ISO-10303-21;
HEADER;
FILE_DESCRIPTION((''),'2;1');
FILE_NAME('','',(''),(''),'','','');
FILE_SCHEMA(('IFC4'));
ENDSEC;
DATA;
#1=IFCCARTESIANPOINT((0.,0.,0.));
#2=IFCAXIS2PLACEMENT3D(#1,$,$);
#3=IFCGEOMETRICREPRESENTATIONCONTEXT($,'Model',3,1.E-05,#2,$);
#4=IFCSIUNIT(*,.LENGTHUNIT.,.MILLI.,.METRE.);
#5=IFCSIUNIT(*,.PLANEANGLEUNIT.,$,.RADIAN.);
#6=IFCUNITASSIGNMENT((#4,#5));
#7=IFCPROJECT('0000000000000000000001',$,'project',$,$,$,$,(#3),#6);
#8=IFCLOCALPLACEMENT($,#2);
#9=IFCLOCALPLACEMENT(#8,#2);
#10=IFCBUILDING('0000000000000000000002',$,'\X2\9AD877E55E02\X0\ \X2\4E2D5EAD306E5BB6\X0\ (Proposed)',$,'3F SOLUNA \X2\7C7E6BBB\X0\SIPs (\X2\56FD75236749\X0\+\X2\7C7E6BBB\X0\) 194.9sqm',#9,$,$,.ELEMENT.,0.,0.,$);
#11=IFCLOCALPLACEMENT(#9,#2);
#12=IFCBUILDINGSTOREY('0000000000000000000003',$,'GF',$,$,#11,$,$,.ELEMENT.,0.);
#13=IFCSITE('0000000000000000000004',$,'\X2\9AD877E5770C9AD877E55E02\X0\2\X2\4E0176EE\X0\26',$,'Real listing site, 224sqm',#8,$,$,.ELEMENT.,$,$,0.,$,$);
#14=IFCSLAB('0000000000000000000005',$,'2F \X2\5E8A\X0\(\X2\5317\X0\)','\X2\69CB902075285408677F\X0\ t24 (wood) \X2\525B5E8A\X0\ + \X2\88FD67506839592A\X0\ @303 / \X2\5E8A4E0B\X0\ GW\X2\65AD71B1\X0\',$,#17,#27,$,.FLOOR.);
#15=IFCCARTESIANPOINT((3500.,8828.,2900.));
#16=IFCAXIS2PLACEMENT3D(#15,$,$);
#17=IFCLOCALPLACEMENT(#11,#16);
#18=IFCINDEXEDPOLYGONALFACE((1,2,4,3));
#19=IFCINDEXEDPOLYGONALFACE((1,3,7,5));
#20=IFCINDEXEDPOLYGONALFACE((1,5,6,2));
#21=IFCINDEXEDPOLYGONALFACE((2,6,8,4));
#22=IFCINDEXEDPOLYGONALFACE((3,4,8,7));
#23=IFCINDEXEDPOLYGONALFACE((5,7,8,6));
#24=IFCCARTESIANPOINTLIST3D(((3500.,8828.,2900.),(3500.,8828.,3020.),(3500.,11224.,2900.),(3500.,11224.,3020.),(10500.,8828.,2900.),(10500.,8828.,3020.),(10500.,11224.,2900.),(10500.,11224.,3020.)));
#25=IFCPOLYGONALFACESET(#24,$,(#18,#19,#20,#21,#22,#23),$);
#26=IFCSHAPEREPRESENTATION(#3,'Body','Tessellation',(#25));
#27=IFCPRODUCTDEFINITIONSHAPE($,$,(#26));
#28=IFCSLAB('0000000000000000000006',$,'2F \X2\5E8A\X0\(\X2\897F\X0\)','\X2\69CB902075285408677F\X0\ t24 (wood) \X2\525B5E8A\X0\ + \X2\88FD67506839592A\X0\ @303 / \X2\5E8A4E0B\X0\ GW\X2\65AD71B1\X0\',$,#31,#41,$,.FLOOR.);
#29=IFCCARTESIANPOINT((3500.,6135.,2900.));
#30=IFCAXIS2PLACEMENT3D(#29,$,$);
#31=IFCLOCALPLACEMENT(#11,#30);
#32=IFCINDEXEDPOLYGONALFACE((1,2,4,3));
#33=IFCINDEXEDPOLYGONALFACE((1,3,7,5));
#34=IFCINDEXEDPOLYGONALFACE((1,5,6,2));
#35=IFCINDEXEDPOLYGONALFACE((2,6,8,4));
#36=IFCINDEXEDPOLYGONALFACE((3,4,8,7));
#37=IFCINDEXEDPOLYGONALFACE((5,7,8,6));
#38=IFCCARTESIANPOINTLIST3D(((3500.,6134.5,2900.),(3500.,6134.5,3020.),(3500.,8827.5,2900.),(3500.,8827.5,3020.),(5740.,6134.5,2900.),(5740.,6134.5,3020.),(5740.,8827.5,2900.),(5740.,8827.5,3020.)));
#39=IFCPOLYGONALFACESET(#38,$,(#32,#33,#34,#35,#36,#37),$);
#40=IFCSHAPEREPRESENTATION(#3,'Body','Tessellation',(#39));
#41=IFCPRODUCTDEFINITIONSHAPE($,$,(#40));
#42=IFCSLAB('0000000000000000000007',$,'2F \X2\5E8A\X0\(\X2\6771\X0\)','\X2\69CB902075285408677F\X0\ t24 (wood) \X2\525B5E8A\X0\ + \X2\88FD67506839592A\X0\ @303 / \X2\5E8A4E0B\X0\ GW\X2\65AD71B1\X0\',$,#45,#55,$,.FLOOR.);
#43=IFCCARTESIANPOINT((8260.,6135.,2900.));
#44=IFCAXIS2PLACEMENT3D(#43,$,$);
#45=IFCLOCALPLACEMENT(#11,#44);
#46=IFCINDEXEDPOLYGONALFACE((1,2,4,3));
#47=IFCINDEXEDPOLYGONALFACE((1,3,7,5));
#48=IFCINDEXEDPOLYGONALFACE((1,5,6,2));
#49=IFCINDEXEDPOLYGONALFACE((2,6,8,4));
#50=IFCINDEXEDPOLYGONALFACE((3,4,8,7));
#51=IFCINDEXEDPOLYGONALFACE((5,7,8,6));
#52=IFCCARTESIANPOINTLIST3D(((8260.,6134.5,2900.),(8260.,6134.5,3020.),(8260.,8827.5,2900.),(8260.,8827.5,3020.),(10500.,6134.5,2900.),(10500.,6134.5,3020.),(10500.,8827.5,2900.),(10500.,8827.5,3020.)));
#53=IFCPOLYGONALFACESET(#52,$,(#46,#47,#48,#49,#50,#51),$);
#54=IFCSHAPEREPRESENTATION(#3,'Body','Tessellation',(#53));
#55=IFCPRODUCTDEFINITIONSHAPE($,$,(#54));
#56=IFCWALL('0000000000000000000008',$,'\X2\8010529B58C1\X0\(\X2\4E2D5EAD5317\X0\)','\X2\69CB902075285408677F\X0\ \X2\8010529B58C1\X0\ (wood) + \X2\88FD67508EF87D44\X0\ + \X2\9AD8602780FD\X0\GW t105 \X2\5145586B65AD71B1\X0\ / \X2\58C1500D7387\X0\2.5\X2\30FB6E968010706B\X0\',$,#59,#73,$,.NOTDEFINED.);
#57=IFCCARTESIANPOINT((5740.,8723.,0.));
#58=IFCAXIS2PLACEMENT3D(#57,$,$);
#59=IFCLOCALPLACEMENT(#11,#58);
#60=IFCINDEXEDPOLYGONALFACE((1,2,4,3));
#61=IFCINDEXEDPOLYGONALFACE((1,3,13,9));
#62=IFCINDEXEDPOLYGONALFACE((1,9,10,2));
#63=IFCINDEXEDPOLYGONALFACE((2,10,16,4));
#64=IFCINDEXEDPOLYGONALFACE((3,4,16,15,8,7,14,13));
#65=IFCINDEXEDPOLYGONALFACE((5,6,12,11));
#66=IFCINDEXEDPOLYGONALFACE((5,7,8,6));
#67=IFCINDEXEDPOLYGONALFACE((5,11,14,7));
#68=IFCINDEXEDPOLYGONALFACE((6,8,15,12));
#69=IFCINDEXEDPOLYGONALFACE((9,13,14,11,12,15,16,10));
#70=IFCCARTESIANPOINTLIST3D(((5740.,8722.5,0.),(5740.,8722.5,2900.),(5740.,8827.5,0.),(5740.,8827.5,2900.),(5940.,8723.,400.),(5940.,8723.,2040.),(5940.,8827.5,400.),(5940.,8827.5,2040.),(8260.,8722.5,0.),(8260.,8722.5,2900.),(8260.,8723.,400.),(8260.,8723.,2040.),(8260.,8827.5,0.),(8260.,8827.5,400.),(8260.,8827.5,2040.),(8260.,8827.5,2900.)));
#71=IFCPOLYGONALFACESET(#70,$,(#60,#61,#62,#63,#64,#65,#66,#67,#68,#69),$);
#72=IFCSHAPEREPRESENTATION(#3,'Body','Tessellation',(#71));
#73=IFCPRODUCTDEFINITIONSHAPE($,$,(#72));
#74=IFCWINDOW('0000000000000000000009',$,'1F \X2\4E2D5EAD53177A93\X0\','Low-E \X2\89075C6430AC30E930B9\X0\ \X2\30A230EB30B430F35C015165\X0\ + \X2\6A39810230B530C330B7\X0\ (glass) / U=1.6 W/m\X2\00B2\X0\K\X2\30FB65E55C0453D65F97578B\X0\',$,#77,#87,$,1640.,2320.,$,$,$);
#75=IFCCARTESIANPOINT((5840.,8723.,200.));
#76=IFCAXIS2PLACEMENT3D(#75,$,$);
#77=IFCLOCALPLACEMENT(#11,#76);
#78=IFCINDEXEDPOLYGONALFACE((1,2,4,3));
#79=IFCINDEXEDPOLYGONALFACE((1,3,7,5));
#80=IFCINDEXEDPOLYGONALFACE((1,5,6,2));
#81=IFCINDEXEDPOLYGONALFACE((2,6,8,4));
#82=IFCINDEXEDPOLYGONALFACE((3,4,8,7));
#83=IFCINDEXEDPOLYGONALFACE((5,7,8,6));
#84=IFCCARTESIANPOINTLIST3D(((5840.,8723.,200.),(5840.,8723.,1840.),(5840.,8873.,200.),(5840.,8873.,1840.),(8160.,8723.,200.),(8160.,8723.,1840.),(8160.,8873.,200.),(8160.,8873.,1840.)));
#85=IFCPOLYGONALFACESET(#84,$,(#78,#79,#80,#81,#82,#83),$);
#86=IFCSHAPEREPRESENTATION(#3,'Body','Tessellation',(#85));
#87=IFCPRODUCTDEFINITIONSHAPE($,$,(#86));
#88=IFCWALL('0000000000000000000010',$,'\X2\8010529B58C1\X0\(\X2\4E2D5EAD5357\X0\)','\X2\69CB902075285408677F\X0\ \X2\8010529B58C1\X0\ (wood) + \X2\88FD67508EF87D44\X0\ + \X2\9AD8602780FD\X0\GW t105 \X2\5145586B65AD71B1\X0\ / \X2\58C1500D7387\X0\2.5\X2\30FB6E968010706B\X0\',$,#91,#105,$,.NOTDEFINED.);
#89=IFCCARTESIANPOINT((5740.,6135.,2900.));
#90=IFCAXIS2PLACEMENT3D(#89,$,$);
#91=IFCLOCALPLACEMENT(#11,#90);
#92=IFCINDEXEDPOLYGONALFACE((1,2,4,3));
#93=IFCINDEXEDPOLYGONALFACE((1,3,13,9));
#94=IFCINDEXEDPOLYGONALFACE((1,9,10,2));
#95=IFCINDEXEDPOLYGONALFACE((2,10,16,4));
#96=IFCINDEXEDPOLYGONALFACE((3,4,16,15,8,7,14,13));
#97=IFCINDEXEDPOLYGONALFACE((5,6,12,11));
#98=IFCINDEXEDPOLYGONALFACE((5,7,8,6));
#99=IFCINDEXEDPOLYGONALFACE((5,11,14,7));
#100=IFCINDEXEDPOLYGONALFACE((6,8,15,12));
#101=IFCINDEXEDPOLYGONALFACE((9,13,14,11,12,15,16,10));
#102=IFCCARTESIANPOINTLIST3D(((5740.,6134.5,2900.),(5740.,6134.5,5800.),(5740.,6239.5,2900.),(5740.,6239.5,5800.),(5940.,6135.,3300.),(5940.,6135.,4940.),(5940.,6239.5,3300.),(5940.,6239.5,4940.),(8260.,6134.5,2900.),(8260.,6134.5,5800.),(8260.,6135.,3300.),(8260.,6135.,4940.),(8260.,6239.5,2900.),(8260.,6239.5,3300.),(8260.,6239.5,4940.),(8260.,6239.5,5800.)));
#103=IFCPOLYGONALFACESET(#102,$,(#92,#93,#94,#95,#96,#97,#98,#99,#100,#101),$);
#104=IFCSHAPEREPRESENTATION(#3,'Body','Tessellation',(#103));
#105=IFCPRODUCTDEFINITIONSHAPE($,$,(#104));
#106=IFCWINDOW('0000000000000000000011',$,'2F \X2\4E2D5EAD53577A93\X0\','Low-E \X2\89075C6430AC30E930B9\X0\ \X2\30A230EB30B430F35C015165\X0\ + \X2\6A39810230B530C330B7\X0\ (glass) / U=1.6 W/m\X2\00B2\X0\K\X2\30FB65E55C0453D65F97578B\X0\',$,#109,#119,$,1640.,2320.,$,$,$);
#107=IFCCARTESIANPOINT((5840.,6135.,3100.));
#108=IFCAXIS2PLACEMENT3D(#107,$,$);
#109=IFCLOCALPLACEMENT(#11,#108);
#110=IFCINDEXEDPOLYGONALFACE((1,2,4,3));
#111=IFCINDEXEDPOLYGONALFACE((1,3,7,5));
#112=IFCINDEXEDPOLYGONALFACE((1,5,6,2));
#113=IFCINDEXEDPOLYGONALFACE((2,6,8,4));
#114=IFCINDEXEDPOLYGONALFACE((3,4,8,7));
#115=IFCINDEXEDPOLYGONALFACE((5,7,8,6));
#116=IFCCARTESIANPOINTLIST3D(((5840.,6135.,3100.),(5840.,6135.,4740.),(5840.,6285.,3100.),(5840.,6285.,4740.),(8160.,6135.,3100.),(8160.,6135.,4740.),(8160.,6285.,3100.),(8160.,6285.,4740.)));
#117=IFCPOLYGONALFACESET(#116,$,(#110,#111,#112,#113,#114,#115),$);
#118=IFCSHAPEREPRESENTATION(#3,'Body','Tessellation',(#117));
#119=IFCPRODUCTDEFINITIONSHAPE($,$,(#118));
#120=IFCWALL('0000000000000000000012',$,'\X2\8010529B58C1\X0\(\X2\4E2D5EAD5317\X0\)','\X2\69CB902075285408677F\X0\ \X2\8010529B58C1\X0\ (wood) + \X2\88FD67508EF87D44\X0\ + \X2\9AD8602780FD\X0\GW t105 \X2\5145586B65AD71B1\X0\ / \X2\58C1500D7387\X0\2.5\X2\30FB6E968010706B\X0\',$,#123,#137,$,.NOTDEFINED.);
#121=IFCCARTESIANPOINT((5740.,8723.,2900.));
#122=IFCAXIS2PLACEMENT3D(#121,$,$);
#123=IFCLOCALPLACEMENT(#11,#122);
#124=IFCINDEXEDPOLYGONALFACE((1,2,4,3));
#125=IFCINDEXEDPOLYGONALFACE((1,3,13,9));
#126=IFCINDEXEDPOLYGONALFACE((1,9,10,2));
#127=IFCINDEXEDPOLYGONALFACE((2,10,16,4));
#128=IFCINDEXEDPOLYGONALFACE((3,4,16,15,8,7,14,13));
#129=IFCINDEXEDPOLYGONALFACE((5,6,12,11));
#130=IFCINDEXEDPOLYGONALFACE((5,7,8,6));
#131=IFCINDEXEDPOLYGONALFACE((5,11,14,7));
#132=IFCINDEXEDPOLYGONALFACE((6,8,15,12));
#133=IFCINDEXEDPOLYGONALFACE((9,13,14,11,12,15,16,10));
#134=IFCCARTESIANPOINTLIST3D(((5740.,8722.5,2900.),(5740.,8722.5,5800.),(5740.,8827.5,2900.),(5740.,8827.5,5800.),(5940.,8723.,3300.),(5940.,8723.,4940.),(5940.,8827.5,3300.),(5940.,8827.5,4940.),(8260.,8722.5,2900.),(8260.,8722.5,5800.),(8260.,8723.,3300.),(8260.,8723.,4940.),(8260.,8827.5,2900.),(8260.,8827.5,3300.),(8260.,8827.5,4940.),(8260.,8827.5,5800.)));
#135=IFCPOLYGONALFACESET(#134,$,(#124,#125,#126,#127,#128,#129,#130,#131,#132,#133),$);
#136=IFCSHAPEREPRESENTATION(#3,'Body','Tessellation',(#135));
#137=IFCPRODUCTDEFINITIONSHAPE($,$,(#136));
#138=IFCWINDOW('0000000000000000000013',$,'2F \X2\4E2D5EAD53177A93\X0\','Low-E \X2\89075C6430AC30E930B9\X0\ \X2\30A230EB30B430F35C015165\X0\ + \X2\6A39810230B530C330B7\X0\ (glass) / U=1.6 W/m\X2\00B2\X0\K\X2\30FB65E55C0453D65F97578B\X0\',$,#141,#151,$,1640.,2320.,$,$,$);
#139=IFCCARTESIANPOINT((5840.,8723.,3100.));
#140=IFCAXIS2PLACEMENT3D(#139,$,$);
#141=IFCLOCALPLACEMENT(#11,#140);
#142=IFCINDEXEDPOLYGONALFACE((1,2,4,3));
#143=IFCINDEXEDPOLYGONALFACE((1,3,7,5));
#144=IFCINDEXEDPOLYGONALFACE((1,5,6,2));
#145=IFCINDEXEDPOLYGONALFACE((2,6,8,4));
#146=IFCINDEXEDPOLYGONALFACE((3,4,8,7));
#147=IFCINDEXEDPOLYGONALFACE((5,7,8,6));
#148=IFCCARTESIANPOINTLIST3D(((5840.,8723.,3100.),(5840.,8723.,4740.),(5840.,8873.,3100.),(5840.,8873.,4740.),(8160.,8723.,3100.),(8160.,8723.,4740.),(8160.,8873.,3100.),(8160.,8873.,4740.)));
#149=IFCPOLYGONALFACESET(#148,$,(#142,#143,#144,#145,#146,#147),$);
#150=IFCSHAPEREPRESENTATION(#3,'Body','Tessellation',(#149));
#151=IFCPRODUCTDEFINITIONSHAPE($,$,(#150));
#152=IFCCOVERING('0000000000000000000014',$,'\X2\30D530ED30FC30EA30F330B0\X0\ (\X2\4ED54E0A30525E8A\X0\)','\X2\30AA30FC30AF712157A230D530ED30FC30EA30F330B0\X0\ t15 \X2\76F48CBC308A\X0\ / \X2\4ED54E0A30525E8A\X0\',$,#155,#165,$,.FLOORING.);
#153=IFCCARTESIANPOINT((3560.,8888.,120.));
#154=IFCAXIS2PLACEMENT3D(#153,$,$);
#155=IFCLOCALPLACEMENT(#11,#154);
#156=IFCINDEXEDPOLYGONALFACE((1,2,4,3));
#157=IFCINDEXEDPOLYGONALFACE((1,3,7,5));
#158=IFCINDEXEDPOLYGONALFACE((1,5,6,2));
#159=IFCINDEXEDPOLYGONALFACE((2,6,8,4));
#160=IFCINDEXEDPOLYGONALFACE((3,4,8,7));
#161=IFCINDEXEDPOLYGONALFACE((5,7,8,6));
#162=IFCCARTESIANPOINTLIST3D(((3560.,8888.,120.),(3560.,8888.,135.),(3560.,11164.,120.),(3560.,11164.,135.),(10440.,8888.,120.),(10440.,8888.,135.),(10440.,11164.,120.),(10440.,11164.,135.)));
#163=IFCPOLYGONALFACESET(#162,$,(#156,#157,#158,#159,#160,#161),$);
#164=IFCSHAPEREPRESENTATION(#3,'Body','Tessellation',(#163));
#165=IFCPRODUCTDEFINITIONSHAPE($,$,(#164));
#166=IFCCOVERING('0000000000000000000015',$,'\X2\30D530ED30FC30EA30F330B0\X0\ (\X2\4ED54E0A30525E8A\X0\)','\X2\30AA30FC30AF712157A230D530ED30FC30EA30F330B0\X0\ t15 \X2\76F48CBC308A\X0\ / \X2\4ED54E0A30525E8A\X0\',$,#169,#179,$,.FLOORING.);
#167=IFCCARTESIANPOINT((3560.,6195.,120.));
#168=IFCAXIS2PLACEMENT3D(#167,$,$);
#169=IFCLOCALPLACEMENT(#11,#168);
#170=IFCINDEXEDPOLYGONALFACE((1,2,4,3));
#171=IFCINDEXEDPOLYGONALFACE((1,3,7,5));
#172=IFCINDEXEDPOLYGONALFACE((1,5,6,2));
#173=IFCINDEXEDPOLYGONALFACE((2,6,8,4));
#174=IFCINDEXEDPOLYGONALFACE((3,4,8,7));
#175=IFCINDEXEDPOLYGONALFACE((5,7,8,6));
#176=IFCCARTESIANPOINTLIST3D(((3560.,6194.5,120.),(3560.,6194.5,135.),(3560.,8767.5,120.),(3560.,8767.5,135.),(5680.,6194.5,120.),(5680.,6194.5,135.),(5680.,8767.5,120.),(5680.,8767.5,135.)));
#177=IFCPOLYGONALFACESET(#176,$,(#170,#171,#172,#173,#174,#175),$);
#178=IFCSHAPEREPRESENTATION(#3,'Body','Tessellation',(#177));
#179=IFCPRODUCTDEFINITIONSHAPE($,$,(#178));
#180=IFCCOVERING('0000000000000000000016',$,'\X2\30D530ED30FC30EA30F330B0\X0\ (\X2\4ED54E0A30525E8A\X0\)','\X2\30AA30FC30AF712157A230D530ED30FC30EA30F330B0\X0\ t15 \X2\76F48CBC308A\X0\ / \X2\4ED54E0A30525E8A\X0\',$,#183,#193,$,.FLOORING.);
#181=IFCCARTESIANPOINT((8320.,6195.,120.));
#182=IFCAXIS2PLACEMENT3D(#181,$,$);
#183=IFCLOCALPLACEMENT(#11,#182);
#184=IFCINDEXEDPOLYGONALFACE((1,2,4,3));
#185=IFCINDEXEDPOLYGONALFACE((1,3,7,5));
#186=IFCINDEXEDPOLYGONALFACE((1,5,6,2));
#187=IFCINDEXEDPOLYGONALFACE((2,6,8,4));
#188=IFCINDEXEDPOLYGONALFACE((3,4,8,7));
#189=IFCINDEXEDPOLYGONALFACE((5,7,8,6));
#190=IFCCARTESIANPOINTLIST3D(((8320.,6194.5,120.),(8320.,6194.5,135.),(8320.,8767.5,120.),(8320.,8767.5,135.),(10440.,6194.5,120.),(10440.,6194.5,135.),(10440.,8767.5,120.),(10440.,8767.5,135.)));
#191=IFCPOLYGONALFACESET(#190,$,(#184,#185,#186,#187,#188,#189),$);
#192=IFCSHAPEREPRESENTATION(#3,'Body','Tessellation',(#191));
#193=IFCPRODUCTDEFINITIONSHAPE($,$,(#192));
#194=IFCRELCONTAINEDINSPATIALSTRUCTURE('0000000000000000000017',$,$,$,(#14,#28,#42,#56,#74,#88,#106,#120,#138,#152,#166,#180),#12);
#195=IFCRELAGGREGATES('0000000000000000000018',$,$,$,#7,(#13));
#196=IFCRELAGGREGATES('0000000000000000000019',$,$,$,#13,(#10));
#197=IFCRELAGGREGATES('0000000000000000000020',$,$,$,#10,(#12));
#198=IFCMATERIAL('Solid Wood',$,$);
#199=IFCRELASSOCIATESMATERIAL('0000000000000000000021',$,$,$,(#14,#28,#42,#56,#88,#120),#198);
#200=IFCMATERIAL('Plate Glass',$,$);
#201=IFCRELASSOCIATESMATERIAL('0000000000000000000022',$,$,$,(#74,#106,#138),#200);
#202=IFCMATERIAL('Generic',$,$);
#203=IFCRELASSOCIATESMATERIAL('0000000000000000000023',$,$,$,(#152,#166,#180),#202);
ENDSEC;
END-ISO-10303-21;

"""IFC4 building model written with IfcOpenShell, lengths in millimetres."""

from ifc_helpers import new_model, si_unit, frame, frame_2d, origin, place, context, project, spatial, rectangle, extrude, material, element, fill, save


model = new_model("IFC4")

# Units and contexts
model_context = context("Model", 3, precision=1e-05, world=origin())
ifc_project = project(units=[si_unit("LENGTHUNIT", "METRE", prefix="MILLI"), si_unit("PLANEANGLEUNIT", "RADIAN")], contexts=[model_context])

# Site, building, storey
site_placement = place(None, origin())
site = spatial("IfcSite", under=ifc_project, at=site_placement, Name="高知県高知市2丁目26", ObjectType="Real listing site, 224sqm", CompositionType="ELEMENT", RefElevation=0.0)
building_placement = place(site_placement, origin())
building = spatial("IfcBuilding", under=site, at=building_placement, Name="高知市 中庭の家 (Proposed)", ObjectType="3F SOLUNA 籾殻SIPs (国産杉+籾殻) 194.9sqm", CompositionType="ELEMENT", ElevationOfRefHeight=0.0, ElevationOfTerrain=0.0)
storey_placement = place(building_placement, origin())
storey = spatial("IfcBuildingStorey", under=building, at=storey_placement, Name="GF", CompositionType="ELEMENT", Elevation=0.0)

# Slabs
ifc_material_1 = material(Name="Solid Wood")
slab_1_placement = place(storey_placement, frame((3500.0, 8828.0, 2900.0)))
element("IfcSlab", 1, at=slab_1_placement, inside=storey, material=ifc_material_1, Name="2F 床(北)", Description="構造用合板 t24 (wood) 剛床 + 製材根太 @303 / 床下 GW断熱", PredefinedType="FLOOR", context=model_context, shape_type="SweptSolid", body=[
    extrude(rectangle(XDim=7000.0, YDim=2396.0, at=frame_2d((3500.0, 1198.0))), frame((3500.0, 8828.0, 2900.0)), (0.0, 0.0, 1.0), 120.0),
])
slab_2_placement = place(storey_placement, frame((3500.0, 6135.0, 2900.0)))
element("IfcSlab", 2, at=slab_2_placement, inside=storey, material=ifc_material_1, Name="2F 床(西)", Description="構造用合板 t24 (wood) 剛床 + 製材根太 @303 / 床下 GW断熱", PredefinedType="FLOOR", context=model_context, shape_type="SweptSolid", body=[
    extrude(rectangle(XDim=2240.0, YDim=2693.0, at=frame_2d((1120.0, 1346.0))), frame((3500.0, 6135.0, 2900.0)), (0.0, 0.0, 1.0), 120.0),
])
slab_3_placement = place(storey_placement, frame((8260.0, 6135.0, 2900.0)))
element("IfcSlab", 3, at=slab_3_placement, inside=storey, material=ifc_material_1, Name="2F 床(東)", Description="構造用合板 t24 (wood) 剛床 + 製材根太 @303 / 床下 GW断熱", PredefinedType="FLOOR", context=model_context, shape_type="SweptSolid", body=[
    extrude(rectangle(XDim=2240.0, YDim=2693.0, at=frame_2d((1120.0, 1346.0))), frame((8260.0, 6135.0, 2900.0)), (0.0, 0.0, 1.0), 120.0),
])

# Wall, opening, window
wall_1_placement = place(storey_placement, frame((5740.0, 8723.0, 0.0)))
wall_1 = element("IfcWall", 4, at=wall_1_placement, inside=storey, material=ifc_material_1, Name="耐力壁(中庭北)", Description="構造用合板 耐力壁 (wood) + 製材軸組 + 高性能GW t105 充填断熱 / 壁倍率2.5・準耐火", PredefinedType="NOTDEFINED", context=model_context, shape_type="SweptSolid", body=[
    extrude(rectangle(XDim=2520.0, YDim=105.0, at=frame_2d((1260.0, 52.0))), frame((5740.0, 8723.0, 0.0)), (0.0, 0.0, 1.0), 2900.0),
])
opening_1_placement = place(storey_placement, frame((5840.0, 8723.0, 200.0)))
opening_1 = element("IfcOpeningElement", 5, at=opening_1_placement, cuts=wall_1, PredefinedType="NOTDEFINED", context=model_context, shape_type="SweptSolid", body=[
    extrude(rectangle(XDim=2320.0, YDim=150.0, at=frame_2d((1160.0, 75.0))), frame((5840.0, 8723.0, 200.0)), (0.0, 0.0, 1.0), 1640.0),
])
ifc_material_2 = material(Name="Plate Glass")
window_1_placement = place(storey_placement, frame((5840.0, 8723.0, 200.0)))
window_1 = element("IfcWindow", 6, at=window_1_placement, inside=storey, material=ifc_material_2, Name="1F 中庭北窓", Description="Low-E 複層ガラス アルゴン封入 + 樹脂サッシ (glass) / U=1.6 W/m²K・日射取得型", OverallHeight=1640.0, OverallWidth=2320.0, context=model_context, shape_type="SweptSolid", body=[
    extrude(rectangle(XDim=2320.0, YDim=150.0, at=frame_2d((1160.0, 75.0))), frame((5840.0, 8723.0, 200.0)), (0.0, 0.0, 1.0), 1640.0),
])
fill(opening_1, window_1)

# Walls, openings, windows
wall_2_placement = place(storey_placement, frame((5740.0, 6135.0, 2900.0)))
wall_2 = element("IfcWall", 7, at=wall_2_placement, inside=storey, material=ifc_material_1, Name="耐力壁(中庭南)", Description="構造用合板 耐力壁 (wood) + 製材軸組 + 高性能GW t105 充填断熱 / 壁倍率2.5・準耐火", PredefinedType="NOTDEFINED", context=model_context, shape_type="SweptSolid", body=[
    extrude(rectangle(XDim=2520.0, YDim=105.0, at=frame_2d((1260.0, 52.0))), frame((5740.0, 6135.0, 2900.0)), (0.0, 0.0, 1.0), 2900.0),
])
opening_2_placement = place(storey_placement, frame((5840.0, 6135.0, 3100.0)))
opening_2 = element("IfcOpeningElement", 8, at=opening_2_placement, cuts=wall_2, PredefinedType="NOTDEFINED", context=model_context, shape_type="SweptSolid", body=[
    extrude(rectangle(XDim=2320.0, YDim=150.0, at=frame_2d((1160.0, 75.0))), frame((5840.0, 6135.0, 3100.0)), (0.0, 0.0, 1.0), 1640.0),
])
window_2_placement = place(storey_placement, frame((5840.0, 6135.0, 3100.0)))
window_2 = element("IfcWindow", 9, at=window_2_placement, inside=storey, material=ifc_material_2, Name="2F 中庭南窓", Description="Low-E 複層ガラス アルゴン封入 + 樹脂サッシ (glass) / U=1.6 W/m²K・日射取得型", OverallHeight=1640.0, OverallWidth=2320.0, context=model_context, shape_type="SweptSolid", body=[
    extrude(rectangle(XDim=2320.0, YDim=150.0, at=frame_2d((1160.0, 75.0))), frame((5840.0, 6135.0, 3100.0)), (0.0, 0.0, 1.0), 1640.0),
])
fill(opening_2, window_2)
wall_3_placement = place(storey_placement, frame((5740.0, 8723.0, 2900.0)))
wall_3 = element("IfcWall", 10, at=wall_3_placement, inside=storey, material=ifc_material_1, Name="耐力壁(中庭北)", Description="構造用合板 耐力壁 (wood) + 製材軸組 + 高性能GW t105 充填断熱 / 壁倍率2.5・準耐火", PredefinedType="NOTDEFINED", context=model_context, shape_type="SweptSolid", body=[
    extrude(rectangle(XDim=2520.0, YDim=105.0, at=frame_2d((1260.0, 52.0))), frame((5740.0, 8723.0, 2900.0)), (0.0, 0.0, 1.0), 2900.0),
])
opening_3_placement = place(storey_placement, frame((5840.0, 8723.0, 3100.0)))
opening_3 = element("IfcOpeningElement", 11, at=opening_3_placement, cuts=wall_3, PredefinedType="NOTDEFINED", context=model_context, shape_type="SweptSolid", body=[
    extrude(rectangle(XDim=2320.0, YDim=150.0, at=frame_2d((1160.0, 75.0))), frame((5840.0, 8723.0, 3100.0)), (0.0, 0.0, 1.0), 1640.0),
])
window_3_placement = place(storey_placement, frame((5840.0, 8723.0, 3100.0)))
window_3 = element("IfcWindow", 12, at=window_3_placement, inside=storey, material=ifc_material_2, Name="2F 中庭北窓", Description="Low-E 複層ガラス アルゴン封入 + 樹脂サッシ (glass) / U=1.6 W/m²K・日射取得型", OverallHeight=1640.0, OverallWidth=2320.0, context=model_context, shape_type="SweptSolid", body=[
    extrude(rectangle(XDim=2320.0, YDim=150.0, at=frame_2d((1160.0, 75.0))), frame((5840.0, 8723.0, 3100.0)), (0.0, 0.0, 1.0), 1640.0),
])
fill(opening_3, window_3)

# Coverings
ifc_material_3 = material(Name="Generic")
covering_1_placement = place(storey_placement, frame((3560.0, 8888.0, 120.0)))
element("IfcCovering", 13, at=covering_1_placement, inside=storey, material=ifc_material_3, Name="フローリング (仕上げ床)", Description="オーク無垢フローリング t15 直貼り / 仕上げ床", PredefinedType="FLOORING", context=model_context, shape_type="SweptSolid", body=[
    extrude(rectangle(XDim=6880.0, YDim=2276.0, at=frame_2d((3440.0, 1138.0))), frame((3560.0, 8888.0, 120.0)), (0.0, 0.0, 1.0), 15.0),
])
covering_2_placement = place(storey_placement, frame((3560.0, 6195.0, 120.0)))
element("IfcCovering", 14, at=covering_2_placement, inside=storey, material=ifc_material_3, Name="フローリング (仕上げ床)", Description="オーク無垢フローリング t15 直貼り / 仕上げ床", PredefinedType="FLOORING", context=model_context, shape_type="SweptSolid", body=[
    extrude(rectangle(XDim=2120.0, YDim=2573.0, at=frame_2d((1060.0, 1286.0))), frame((3560.0, 6195.0, 120.0)), (0.0, 0.0, 1.0), 15.0),
])
covering_3_placement = place(storey_placement, frame((8320.0, 6195.0, 120.0)))
element("IfcCovering", 15, at=covering_3_placement, inside=storey, material=ifc_material_3, Name="フローリング (仕上げ床)", Description="オーク無垢フローリング t15 直貼り / 仕上げ床", PredefinedType="FLOORING", context=model_context, shape_type="SweptSolid", body=[
    extrude(rectangle(XDim=2120.0, YDim=2573.0, at=frame_2d((1060.0, 1286.0))), frame((8320.0, 6195.0, 120.0)), (0.0, 0.0, 1.0), 15.0),
])

save(model, "model.ifc")
